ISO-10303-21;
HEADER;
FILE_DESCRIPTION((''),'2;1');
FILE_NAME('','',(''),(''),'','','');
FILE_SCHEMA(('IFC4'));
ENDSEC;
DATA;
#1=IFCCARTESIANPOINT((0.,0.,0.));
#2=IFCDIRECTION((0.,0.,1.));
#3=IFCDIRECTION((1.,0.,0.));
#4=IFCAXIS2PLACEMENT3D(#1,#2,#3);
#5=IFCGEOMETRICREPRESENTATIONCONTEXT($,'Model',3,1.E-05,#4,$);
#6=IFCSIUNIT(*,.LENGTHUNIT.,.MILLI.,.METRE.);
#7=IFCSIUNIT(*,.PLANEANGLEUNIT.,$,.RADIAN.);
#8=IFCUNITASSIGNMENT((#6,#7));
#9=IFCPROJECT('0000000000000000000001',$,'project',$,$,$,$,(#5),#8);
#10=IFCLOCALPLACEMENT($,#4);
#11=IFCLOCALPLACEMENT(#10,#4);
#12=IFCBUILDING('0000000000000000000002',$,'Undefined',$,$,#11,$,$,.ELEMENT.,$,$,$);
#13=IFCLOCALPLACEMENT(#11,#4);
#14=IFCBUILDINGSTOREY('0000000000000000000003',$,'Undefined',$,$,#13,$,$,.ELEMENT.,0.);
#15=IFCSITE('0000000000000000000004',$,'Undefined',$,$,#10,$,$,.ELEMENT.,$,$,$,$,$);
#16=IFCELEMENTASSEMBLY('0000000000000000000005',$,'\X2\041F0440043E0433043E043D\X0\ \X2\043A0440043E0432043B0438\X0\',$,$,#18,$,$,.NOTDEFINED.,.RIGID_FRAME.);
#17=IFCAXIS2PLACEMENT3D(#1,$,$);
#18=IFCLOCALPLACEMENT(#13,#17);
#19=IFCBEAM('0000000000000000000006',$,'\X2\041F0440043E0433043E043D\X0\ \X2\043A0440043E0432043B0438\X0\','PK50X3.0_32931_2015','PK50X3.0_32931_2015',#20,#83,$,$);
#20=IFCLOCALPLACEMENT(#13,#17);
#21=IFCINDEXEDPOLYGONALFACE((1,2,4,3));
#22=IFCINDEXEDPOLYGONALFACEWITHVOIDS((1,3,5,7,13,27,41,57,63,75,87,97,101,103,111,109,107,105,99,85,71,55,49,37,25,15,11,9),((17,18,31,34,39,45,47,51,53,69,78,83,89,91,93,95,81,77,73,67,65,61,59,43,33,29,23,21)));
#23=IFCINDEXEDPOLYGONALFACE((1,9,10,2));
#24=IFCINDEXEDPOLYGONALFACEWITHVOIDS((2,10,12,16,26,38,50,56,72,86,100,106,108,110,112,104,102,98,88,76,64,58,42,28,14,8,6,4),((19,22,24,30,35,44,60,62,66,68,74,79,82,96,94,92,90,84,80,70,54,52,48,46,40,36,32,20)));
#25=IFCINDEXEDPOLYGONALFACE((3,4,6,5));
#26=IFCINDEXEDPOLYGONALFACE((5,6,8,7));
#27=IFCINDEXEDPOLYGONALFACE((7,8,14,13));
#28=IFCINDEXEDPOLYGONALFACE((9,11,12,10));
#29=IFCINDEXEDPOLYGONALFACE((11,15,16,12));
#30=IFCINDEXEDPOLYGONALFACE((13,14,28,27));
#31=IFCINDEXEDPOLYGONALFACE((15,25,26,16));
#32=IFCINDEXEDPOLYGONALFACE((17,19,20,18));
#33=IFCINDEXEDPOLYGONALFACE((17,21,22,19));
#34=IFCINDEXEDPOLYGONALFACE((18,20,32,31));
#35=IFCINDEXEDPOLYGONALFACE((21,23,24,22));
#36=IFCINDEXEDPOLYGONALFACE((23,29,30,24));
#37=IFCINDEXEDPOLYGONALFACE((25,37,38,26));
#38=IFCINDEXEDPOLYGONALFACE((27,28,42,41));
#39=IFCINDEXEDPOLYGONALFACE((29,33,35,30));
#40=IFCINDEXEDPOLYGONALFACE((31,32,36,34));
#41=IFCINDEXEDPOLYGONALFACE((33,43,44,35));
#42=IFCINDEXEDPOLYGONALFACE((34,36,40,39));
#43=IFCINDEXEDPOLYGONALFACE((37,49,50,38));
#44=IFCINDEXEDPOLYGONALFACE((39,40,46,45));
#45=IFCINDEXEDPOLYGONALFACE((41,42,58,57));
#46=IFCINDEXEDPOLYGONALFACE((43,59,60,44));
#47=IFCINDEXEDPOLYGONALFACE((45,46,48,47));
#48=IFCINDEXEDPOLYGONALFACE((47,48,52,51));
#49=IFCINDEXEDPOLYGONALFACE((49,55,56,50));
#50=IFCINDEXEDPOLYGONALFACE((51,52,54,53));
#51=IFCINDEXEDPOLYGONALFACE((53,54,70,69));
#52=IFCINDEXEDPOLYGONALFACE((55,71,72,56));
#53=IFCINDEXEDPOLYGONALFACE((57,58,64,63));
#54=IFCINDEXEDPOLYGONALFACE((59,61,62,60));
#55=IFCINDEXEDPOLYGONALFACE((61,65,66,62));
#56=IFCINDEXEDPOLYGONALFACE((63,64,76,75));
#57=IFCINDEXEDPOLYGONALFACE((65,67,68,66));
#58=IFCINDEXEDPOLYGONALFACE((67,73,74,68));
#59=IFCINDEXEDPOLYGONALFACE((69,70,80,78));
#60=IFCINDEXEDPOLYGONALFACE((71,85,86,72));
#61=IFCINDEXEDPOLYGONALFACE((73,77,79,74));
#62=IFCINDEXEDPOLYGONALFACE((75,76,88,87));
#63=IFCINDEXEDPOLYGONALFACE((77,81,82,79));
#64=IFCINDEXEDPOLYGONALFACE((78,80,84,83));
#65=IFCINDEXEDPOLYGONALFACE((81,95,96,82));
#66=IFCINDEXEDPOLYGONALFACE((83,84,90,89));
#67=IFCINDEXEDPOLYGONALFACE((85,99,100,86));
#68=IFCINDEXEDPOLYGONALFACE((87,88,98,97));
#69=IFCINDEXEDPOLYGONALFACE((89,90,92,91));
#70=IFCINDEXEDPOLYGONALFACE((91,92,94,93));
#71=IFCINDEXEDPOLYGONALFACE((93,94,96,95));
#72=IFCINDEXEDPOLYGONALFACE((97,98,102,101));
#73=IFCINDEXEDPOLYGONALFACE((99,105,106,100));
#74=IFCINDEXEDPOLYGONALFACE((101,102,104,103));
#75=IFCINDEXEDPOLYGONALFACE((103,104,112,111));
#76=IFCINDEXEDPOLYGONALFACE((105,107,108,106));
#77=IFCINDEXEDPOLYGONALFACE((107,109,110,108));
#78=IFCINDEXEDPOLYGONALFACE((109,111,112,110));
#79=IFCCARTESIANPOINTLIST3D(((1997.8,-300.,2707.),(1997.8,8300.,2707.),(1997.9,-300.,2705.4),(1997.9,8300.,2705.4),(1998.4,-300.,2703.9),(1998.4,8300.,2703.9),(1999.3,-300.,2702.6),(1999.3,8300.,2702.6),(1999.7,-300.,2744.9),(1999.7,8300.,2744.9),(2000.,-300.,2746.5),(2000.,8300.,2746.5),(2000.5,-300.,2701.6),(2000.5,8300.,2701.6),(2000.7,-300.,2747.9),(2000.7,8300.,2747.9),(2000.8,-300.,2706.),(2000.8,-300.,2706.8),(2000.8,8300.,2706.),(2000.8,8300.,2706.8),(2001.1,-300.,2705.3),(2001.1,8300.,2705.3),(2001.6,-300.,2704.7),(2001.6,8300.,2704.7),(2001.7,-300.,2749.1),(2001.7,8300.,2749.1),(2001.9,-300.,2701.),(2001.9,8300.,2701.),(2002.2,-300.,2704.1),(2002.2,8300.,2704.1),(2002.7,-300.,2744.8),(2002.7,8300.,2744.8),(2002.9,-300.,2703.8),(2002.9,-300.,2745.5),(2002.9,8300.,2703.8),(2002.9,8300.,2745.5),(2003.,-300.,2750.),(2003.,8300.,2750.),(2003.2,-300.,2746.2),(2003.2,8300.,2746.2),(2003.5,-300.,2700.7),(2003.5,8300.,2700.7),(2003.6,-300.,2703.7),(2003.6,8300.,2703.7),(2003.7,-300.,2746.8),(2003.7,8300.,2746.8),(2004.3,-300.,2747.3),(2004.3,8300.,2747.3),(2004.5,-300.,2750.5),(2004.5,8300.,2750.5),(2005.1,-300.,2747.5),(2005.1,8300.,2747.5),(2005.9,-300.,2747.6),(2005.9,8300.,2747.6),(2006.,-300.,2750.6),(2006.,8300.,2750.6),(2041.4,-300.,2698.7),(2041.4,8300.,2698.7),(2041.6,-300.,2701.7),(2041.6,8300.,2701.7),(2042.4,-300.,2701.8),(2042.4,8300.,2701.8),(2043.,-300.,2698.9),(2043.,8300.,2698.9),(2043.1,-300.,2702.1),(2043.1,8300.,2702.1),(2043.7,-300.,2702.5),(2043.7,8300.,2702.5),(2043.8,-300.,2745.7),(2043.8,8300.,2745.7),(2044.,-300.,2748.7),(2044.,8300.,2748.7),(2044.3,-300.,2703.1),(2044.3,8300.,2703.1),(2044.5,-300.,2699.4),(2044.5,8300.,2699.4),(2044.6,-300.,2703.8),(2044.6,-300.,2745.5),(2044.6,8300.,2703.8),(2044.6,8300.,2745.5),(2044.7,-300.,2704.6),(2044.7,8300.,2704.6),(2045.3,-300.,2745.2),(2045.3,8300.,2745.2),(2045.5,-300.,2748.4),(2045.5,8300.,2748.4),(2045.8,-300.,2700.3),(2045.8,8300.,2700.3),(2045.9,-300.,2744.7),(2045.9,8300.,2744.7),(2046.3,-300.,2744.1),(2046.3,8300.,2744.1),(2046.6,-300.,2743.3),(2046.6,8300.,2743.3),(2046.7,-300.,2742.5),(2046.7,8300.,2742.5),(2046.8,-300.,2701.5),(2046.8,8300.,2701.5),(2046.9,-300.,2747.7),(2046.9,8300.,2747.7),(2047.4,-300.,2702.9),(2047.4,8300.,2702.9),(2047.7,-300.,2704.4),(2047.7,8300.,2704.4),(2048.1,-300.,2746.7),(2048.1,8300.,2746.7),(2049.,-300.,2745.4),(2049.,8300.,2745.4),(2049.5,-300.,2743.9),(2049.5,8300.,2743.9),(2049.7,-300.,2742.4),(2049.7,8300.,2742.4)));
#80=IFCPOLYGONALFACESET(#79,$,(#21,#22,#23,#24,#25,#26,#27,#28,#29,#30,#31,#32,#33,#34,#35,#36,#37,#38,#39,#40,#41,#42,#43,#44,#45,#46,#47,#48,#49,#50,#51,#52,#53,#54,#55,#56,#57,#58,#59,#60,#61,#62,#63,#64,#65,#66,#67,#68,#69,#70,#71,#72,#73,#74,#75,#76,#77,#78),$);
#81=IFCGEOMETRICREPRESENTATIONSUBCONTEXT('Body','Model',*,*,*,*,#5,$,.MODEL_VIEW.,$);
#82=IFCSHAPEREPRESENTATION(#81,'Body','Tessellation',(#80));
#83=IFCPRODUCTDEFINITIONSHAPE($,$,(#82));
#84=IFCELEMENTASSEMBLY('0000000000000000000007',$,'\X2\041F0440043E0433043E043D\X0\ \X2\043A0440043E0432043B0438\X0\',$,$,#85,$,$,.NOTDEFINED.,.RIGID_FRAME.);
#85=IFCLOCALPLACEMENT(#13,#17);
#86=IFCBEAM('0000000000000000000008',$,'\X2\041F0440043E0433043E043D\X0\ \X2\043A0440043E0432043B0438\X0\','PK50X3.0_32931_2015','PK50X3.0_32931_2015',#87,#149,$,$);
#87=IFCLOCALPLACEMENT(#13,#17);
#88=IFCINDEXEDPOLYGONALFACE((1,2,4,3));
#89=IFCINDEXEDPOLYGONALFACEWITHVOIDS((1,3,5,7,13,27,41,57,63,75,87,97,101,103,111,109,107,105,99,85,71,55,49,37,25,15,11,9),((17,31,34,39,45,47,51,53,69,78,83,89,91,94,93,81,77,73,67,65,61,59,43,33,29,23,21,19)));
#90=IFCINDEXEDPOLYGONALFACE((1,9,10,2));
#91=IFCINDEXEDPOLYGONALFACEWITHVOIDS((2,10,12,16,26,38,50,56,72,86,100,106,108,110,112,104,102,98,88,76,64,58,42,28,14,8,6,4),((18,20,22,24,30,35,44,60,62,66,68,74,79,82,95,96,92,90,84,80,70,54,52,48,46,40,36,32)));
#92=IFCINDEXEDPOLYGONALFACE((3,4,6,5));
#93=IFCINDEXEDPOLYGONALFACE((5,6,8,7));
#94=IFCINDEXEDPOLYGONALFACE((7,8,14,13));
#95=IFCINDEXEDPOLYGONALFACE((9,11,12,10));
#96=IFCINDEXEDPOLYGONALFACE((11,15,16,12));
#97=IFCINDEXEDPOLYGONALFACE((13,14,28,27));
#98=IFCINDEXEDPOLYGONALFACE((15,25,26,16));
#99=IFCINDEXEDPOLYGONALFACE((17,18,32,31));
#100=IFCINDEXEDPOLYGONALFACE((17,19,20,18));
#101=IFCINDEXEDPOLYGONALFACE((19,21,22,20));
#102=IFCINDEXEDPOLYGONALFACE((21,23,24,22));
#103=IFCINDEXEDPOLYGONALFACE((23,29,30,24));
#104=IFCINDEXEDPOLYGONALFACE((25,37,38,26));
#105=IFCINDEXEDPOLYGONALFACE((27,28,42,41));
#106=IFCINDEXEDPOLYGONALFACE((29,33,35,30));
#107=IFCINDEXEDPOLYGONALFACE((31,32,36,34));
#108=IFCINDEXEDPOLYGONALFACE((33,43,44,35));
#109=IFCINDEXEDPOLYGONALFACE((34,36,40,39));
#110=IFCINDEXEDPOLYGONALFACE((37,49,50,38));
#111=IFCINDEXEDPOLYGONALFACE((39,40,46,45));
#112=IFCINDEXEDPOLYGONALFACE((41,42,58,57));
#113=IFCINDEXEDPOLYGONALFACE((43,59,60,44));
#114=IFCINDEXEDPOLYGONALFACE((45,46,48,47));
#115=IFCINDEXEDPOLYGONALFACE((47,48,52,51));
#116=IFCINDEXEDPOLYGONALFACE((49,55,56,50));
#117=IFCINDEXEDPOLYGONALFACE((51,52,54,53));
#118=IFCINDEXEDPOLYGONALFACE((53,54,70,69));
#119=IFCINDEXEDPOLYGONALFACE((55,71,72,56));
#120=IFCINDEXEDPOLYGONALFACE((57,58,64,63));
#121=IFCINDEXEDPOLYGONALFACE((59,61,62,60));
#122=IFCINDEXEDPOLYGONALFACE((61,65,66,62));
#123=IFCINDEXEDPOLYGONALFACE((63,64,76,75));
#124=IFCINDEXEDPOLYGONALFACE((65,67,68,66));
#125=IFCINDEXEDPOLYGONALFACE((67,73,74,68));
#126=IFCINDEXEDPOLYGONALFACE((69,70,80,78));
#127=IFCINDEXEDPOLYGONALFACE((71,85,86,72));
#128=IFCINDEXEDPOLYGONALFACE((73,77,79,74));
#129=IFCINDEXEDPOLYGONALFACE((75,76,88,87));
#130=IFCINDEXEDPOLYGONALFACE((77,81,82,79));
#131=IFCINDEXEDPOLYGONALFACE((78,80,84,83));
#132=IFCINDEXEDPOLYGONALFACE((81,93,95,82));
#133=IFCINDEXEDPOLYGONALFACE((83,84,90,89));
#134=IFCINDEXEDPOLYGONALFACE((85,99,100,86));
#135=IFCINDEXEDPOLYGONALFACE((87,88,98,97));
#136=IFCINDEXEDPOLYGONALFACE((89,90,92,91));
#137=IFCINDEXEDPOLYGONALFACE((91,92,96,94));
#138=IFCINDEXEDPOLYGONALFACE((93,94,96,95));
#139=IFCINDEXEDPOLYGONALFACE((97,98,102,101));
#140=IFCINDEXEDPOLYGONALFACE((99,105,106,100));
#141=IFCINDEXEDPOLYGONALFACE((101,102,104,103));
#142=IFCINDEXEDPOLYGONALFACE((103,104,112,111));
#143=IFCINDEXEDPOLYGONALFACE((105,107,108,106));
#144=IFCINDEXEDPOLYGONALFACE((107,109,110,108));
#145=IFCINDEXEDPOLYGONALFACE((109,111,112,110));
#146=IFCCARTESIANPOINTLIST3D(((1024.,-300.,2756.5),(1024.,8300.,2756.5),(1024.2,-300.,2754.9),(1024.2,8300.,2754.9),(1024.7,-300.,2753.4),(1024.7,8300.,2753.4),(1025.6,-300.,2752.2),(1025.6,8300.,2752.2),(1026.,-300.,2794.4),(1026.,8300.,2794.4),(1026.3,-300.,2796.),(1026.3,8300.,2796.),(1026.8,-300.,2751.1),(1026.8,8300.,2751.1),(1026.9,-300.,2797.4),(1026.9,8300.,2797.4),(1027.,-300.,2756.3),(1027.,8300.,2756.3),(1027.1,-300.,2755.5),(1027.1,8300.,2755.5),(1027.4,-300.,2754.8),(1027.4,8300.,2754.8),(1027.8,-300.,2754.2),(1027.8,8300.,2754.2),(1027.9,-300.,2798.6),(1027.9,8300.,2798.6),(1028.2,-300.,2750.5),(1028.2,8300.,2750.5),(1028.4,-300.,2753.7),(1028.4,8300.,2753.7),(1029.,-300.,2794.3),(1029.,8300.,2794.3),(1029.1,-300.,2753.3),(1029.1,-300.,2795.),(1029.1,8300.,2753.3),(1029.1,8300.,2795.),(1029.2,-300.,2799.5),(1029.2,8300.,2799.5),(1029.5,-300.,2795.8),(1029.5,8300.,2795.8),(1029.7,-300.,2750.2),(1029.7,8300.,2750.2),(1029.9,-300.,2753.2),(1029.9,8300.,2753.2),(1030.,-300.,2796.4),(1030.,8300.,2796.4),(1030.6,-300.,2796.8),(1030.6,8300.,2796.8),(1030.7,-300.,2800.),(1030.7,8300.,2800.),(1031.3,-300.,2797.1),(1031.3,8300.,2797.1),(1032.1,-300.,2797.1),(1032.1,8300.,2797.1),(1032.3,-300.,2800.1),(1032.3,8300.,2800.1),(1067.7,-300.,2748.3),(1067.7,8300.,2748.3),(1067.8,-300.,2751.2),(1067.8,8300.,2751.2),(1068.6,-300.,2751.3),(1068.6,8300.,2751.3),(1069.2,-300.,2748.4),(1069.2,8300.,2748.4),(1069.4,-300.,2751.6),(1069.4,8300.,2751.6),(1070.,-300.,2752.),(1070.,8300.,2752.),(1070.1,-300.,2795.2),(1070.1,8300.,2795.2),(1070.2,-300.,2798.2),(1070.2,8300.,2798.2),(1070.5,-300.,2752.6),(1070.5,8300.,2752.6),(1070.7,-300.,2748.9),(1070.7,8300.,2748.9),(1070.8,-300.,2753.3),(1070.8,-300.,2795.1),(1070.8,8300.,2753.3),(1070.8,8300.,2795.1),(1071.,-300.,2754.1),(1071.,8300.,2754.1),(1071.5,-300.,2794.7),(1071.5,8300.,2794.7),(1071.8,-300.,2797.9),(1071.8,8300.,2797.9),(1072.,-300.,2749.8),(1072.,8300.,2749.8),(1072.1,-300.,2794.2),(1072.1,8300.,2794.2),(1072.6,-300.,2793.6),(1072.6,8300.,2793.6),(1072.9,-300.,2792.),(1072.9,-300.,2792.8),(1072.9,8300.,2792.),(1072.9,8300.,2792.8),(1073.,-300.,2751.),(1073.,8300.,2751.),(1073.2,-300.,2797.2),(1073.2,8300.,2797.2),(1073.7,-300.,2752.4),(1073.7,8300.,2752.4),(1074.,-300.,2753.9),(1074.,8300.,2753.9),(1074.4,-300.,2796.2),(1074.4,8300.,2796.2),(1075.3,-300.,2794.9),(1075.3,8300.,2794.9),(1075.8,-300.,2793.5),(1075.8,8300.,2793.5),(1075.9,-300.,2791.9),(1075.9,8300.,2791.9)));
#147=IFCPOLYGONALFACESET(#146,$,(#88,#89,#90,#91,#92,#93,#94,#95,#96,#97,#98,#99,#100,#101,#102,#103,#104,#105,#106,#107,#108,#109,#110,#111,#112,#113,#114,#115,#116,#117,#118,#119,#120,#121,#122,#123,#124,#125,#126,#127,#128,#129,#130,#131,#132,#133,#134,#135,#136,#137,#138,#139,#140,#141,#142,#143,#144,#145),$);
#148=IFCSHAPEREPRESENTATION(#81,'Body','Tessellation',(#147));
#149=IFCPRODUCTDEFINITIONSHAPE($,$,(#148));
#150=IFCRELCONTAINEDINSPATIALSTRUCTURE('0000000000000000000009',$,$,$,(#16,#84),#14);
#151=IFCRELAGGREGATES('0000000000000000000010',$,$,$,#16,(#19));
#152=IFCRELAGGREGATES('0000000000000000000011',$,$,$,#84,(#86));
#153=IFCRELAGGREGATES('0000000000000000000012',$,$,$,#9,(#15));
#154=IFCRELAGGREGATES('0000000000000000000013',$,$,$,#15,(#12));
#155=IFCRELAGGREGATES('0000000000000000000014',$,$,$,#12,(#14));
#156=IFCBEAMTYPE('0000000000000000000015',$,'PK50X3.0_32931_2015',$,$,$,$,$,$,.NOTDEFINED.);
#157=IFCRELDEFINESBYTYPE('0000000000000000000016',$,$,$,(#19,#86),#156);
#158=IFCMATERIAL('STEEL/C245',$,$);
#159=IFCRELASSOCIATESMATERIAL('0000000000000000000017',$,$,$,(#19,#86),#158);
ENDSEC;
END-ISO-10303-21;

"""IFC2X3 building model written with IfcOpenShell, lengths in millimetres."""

from ifc_helpers import new_model, si_unit, frame, origin_with_axes, origin_2d_with_axis, place, context, subcontext, project, spatial, hollow_rectangle, extrude, material, type_object, element, aggregate, save


model = new_model("IFC2X3")

# Units and contexts
model_context = context("Model", 3, precision=1e-05, world=origin_with_axes())
body_context = subcontext(model_context, "Body", "Model", "MODEL_VIEW")
ifc_project = project(units=[si_unit("LENGTHUNIT", "METRE", prefix="MILLI"), si_unit("PLANEANGLEUNIT", "RADIAN")], contexts=[model_context])

# Site, building, storey
site_placement = place(None, origin_with_axes())
site = spatial("IfcSite", under=ifc_project, at=site_placement, Name="Undefined", CompositionType="ELEMENT")
building_placement = place(site_placement, origin_with_axes())
building = spatial("IfcBuilding", under=site, at=building_placement, Name="Undefined", CompositionType="ELEMENT")
storey_placement = place(building_placement, origin_with_axes())
storey = spatial("IfcBuildingStorey", under=building, at=storey_placement, Name="Undefined", CompositionType="ELEMENT", Elevation=0.0)

# Shared definitions
ifc_material_1 = material(Name="STEEL/C245")

# Shared definitions
beam_type_1 = type_object("IfcBeamType", Name="PK50X3.0_32931_2015", PredefinedType="NOTDEFINED")

# Element assemblies, beams
assembly_1_placement = place(storey_placement, origin_with_axes())
assembly_1 = element("IfcElementAssembly", 1, at=assembly_1_placement, inside=storey, Name="Прогон кровли", AssemblyPlace="NOTDEFINED", PredefinedType="RIGID_FRAME")
beam_1_placement = place(assembly_1_placement, frame((2023.7, -300.0, 2724.7), z_axis=(0.050782, 0.0, 0.99871), x_axis=(0.0, 1.0, 0.0)))
beam_1 = element("IfcBeam", 2, at=beam_1_placement, type_object=beam_type_1, material=ifc_material_1, Name="Прогон кровли", Description="PK50X3.0_32931_2015", ObjectType="PK50X3.0_32931_2015", context=body_context, shape_type="SweptSolid", body=[
    extrude(hollow_rectangle(XDim=50.0, YDim=50.0, WallThickness=3.0, InnerFilletRadius=3.0, OuterFilletRadius=6.0, at=origin_2d_with_axis()), frame((8600.0, 0.0, 0.0), z_axis=(-1.0, 0.0, 0.0), x_axis=(0.0, -1.0, 0.0)), (0.0, 0.0, 1.0), 8600.0),
])
aggregate(assembly_1, [beam_1])
assembly_2_placement = place(storey_placement, origin_with_axes())
assembly_2 = element("IfcElementAssembly", 3, at=assembly_2_placement, inside=storey, Name="Прогон кровли", AssemblyPlace="NOTDEFINED", PredefinedType="RIGID_FRAME")
beam_2_placement = place(assembly_2_placement, frame((1050.0, -300.0, 2774.2), z_axis=(0.050782, 0.0, 0.99871), x_axis=(0.0, 1.0, 0.0)))
beam_2 = element("IfcBeam", 4, at=beam_2_placement, type_object=beam_type_1, material=ifc_material_1, Name="Прогон кровли", Description="PK50X3.0_32931_2015", ObjectType="PK50X3.0_32931_2015", context=body_context, shape_type="SweptSolid", body=[
    extrude(hollow_rectangle(XDim=50.0, YDim=50.0, WallThickness=3.0, InnerFilletRadius=3.0, OuterFilletRadius=6.0, at=origin_2d_with_axis()), frame((8600.0, 0.0, 0.0), z_axis=(-1.0, 0.0, 0.0), x_axis=(0.0, -1.0, 0.0)), (0.0, 0.0, 1.0), 8600.0),
])
aggregate(assembly_2, [beam_2])

save(model, "model.ifc")
